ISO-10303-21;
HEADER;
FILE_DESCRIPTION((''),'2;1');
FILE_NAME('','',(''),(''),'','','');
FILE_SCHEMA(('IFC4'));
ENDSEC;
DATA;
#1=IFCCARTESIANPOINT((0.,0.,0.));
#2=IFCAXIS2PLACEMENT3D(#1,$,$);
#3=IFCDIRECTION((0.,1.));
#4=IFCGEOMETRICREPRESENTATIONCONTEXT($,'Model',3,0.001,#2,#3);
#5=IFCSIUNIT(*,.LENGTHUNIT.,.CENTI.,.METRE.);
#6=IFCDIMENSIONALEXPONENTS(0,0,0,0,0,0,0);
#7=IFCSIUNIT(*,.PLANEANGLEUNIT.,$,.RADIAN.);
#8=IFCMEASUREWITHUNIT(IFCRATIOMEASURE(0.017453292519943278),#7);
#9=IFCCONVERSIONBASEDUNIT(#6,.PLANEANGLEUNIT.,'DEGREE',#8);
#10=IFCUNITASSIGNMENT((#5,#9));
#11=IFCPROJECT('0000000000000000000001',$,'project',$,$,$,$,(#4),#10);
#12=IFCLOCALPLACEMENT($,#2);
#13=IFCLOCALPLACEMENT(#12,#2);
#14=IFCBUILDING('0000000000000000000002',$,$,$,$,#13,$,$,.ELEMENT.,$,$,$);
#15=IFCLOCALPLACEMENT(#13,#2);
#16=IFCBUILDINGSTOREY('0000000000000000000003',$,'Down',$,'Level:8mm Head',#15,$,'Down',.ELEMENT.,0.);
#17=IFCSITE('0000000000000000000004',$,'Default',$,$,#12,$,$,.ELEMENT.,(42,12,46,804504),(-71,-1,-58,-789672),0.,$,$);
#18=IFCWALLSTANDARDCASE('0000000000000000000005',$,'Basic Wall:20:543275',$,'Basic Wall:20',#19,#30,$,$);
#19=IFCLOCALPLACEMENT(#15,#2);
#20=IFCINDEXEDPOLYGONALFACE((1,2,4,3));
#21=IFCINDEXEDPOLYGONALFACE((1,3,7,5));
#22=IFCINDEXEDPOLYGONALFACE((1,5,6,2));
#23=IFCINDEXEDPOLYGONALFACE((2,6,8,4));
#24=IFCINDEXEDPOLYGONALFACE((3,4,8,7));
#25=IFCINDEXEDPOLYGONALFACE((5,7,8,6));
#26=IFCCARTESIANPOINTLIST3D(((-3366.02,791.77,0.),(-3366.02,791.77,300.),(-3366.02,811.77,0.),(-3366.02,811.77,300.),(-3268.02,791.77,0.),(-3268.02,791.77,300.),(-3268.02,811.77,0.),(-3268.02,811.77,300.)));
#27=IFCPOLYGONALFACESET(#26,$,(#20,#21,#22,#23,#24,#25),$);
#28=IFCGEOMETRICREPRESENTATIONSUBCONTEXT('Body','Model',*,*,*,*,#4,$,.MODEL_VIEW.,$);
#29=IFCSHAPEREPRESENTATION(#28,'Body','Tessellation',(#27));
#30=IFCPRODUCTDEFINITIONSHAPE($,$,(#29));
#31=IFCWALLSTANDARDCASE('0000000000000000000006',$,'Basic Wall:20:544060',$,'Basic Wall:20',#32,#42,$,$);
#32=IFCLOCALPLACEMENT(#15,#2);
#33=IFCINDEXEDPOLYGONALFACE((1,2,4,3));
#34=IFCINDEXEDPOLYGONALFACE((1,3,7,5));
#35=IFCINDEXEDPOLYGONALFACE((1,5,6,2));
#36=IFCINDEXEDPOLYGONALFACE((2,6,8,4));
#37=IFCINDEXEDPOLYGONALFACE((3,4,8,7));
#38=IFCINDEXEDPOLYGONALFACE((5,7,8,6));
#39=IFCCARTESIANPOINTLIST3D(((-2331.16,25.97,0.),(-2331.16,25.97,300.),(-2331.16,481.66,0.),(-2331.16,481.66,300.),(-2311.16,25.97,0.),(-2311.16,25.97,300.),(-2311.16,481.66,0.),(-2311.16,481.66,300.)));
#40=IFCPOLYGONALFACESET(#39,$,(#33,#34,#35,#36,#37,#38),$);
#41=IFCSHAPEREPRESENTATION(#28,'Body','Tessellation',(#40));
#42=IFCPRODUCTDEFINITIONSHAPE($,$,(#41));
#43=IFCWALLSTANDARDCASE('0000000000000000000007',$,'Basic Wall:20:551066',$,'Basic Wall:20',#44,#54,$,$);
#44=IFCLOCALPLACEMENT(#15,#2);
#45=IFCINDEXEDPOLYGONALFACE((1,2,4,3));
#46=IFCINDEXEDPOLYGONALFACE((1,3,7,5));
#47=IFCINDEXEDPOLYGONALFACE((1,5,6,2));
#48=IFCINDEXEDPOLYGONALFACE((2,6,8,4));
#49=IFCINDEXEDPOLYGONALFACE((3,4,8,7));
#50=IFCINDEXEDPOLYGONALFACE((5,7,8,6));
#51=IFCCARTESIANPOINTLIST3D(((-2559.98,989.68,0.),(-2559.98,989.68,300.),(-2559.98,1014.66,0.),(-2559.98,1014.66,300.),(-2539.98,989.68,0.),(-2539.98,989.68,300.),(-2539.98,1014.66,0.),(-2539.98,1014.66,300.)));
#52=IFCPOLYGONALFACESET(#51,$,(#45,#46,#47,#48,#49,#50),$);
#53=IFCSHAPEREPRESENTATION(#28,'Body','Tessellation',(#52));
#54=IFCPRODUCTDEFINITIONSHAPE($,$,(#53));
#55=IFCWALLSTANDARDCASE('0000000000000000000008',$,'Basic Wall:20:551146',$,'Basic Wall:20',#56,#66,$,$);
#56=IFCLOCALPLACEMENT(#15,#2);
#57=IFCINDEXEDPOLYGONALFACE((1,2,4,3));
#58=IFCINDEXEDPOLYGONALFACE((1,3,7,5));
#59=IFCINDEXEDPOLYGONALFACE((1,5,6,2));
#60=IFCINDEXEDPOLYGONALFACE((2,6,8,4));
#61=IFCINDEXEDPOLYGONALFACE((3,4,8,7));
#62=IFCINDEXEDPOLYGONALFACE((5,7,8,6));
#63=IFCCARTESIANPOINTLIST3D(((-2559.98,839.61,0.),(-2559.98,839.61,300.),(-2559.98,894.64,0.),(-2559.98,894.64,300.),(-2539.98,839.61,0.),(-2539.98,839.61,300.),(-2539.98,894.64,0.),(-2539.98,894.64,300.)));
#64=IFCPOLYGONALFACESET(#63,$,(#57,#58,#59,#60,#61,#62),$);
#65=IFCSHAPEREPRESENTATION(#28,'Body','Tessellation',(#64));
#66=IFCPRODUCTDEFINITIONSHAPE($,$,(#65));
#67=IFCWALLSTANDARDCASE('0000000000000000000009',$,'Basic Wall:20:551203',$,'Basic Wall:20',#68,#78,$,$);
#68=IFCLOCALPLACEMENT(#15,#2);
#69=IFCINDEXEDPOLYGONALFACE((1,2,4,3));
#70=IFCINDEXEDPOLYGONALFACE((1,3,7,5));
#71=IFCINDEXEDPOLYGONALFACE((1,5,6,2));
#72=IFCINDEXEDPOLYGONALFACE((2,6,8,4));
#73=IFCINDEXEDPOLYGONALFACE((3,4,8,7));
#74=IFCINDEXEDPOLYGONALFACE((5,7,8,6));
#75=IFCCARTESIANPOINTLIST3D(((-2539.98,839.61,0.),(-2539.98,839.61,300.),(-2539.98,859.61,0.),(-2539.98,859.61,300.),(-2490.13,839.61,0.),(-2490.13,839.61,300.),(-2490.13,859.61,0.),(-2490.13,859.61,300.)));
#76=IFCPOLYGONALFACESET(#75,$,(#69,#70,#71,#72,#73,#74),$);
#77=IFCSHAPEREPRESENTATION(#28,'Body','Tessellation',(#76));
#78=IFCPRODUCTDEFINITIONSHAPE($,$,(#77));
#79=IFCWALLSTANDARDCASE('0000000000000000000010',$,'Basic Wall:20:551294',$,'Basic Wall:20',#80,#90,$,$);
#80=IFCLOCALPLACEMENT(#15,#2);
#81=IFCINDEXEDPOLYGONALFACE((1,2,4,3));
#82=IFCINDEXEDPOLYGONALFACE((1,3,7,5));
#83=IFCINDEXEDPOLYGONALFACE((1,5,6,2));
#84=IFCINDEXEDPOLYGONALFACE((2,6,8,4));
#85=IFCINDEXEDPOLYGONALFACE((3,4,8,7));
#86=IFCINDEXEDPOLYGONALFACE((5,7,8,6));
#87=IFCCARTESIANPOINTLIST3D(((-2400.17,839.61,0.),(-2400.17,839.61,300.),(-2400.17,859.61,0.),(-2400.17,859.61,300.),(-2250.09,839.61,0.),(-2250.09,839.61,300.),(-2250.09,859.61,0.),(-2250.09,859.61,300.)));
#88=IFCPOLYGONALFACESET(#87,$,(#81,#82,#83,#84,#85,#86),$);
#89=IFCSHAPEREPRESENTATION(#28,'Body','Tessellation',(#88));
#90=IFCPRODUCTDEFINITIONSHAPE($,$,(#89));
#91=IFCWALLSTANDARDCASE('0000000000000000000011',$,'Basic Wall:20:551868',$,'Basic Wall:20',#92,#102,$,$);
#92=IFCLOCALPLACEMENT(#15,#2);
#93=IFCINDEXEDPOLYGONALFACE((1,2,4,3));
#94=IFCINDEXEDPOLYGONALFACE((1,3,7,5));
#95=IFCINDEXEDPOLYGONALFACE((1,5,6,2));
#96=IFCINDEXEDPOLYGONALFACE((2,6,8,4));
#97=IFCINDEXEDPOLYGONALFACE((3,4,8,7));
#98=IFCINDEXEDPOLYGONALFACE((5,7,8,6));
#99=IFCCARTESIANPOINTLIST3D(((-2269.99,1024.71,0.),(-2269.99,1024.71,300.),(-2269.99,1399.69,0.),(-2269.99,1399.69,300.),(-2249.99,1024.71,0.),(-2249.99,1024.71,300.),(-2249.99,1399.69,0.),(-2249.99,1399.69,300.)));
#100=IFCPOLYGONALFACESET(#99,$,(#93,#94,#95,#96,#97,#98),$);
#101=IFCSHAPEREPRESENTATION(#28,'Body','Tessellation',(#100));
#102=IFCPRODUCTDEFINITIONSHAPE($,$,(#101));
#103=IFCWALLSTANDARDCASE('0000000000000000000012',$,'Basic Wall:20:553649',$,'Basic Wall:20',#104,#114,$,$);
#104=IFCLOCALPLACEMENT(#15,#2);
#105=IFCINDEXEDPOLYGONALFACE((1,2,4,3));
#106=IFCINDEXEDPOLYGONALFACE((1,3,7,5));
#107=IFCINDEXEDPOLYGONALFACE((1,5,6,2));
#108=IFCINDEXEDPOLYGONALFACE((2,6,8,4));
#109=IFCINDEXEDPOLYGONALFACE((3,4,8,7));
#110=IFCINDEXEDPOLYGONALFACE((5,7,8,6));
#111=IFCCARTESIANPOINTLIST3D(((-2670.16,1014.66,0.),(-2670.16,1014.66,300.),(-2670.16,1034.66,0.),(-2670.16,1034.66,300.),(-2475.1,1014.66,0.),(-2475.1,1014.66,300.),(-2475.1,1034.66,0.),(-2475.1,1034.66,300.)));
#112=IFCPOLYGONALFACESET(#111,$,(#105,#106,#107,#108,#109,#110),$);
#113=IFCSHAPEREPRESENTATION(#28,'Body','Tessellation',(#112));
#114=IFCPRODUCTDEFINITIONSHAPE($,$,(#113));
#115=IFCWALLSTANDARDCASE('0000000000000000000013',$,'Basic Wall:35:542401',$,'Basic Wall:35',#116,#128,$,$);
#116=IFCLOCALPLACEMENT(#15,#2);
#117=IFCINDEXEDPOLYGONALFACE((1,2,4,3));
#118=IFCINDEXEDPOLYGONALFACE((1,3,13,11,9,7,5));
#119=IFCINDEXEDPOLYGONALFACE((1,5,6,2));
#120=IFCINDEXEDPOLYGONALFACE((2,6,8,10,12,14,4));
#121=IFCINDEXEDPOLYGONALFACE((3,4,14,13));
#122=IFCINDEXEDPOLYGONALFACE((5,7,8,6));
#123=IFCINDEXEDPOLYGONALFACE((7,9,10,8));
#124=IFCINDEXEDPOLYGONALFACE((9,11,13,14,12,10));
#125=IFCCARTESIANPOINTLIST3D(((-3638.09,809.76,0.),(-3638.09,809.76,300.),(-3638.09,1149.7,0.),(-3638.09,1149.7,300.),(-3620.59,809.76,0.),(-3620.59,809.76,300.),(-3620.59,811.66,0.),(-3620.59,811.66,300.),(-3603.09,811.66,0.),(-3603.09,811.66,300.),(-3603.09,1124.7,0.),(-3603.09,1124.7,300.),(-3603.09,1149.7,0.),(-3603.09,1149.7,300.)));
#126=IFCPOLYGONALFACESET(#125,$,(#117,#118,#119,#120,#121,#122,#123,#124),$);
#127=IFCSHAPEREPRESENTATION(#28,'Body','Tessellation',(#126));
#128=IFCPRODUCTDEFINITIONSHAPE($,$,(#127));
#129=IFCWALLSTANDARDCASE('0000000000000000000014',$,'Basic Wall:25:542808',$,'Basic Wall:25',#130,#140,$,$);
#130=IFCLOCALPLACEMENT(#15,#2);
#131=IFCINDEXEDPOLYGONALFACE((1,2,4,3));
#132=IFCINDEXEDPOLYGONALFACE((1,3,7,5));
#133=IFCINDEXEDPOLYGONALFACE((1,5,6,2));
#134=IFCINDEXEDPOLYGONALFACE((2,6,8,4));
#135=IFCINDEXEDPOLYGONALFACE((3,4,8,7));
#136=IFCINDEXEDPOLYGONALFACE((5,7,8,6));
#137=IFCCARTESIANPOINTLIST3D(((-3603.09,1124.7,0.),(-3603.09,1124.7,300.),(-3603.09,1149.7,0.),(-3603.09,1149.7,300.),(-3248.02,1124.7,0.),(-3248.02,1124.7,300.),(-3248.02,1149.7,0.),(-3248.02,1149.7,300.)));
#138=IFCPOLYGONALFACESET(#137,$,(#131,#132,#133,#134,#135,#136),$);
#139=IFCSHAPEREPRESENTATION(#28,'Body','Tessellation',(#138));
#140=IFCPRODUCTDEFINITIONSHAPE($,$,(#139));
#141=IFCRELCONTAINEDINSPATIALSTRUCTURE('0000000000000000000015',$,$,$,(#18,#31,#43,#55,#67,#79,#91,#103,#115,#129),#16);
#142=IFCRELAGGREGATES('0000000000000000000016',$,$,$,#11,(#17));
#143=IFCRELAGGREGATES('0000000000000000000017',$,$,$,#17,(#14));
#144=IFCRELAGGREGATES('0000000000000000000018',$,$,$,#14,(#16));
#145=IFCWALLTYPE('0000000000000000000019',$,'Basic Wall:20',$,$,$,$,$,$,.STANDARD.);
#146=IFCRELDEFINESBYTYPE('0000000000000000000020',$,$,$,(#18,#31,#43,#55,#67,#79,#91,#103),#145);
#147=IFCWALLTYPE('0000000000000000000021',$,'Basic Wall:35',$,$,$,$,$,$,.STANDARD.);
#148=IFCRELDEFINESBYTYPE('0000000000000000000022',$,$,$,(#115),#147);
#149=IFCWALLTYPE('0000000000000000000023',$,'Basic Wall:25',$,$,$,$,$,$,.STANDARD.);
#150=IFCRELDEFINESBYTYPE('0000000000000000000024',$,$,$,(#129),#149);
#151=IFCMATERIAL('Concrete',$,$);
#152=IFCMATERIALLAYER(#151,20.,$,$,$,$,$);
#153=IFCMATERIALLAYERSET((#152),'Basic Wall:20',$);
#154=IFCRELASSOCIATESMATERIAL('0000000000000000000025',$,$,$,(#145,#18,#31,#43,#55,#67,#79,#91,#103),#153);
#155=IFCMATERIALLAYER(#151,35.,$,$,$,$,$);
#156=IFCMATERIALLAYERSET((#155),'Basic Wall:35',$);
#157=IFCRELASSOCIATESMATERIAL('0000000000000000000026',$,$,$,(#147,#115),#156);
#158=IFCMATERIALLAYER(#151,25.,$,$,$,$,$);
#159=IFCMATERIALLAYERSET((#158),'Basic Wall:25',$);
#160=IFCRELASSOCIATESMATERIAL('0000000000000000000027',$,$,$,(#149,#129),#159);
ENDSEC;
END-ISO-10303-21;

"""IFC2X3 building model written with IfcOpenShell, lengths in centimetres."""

from ifc_helpers import new_model, entity, si_unit, converted_unit, direction, frame, frame_2d, origin, place, context, subcontext, project, spatial, polyline, rectangle, outline, extrude, material, layer, layer_set, layer_usage, type_object, element, save


model = new_model("IFC2X3")

# Units and contexts
model_context = context("Model", 3, precision=0.001, world=origin(), true_north=direction((0.0, 1.0)))
body_context = subcontext(model_context, "Body", "Model", "MODEL_VIEW")
ifc_project = project(units=[si_unit("LENGTHUNIT", "METRE", prefix="CENTI"), converted_unit("PLANEANGLEUNIT", "DEGREE", entity("IfcRatioMeasure", 0.017453292519943278), si_unit("PLANEANGLEUNIT", "RADIAN"), dimensions=[0, 0, 0, 0, 0, 0, 0])], contexts=[model_context])

# Site, building, storey
site_placement = place(None, origin())
site = spatial("IfcSite", under=ifc_project, at=site_placement, Name="Default", CompositionType="ELEMENT", RefLatitude=(42, 12, 46, 804504), RefLongitude=(-71, -1, -58, -789672), RefElevation=0.0)
building_placement = place(site_placement, origin())
building = spatial("IfcBuilding", under=site, at=building_placement, CompositionType="ELEMENT")
storey_placement = place(building_placement, origin())
storey = spatial("IfcBuildingStorey", under=building, at=storey_placement, Name="Down", ObjectType="Level:8mm Head", LongName="Down", CompositionType="ELEMENT", Elevation=0.0)

# Walls
ifc_material = material(Name="Concrete")
ifc_layer_1 = layer(ifc_material, 20.0)
ifc_layer_set_1 = layer_set([ifc_layer_1], Name="Basic Wall:20")
wall_type_1 = type_object("IfcWallType", Name="Basic Wall:20", PredefinedType="STANDARD", material=ifc_layer_set_1)
ifc_layer_usage_1 = layer_usage(ifc_layer_set_1, "AXIS2", "NEGATIVE", 10.0)
wall_1_placement = place(storey_placement, frame((-3268.02, 801.77, 0.0), z_axis=(0.0, 0.0, 1.0), x_axis=(-1.0, 0.0, 0.0)))
element("IfcWallStandardCase", 1, at=wall_1_placement, inside=storey, type_object=wall_type_1, material=ifc_layer_usage_1, Name="Basic Wall:20:543275", ObjectType="Basic Wall:20", context=body_context, shape_type="SweptSolid", body=[
    extrude(rectangle(XDim=98.0, YDim=20.0, at=frame_2d((49.0, 0.0), x_axis=(-1.0, 0.0))), origin(), (0.0, 0.0, 1.0), 300.0),
])
ifc_layer_usage_2 = layer_usage(ifc_layer_set_1, "AXIS2", "POSITIVE", -10.0)
wall_2_placement = place(storey_placement, frame((-2321.16, 481.66, 0.0), z_axis=(0.0, 0.0, 1.0), x_axis=(0.0, -1.0, 0.0)))
element("IfcWallStandardCase", 2, at=wall_2_placement, inside=storey, type_object=wall_type_1, material=ifc_layer_usage_2, Name="Basic Wall:20:544060", ObjectType="Basic Wall:20", context=body_context, shape_type="SweptSolid", body=[
    extrude(rectangle(XDim=455.69, YDim=20.0, at=frame_2d((227.85, 0.0), x_axis=(-1.0, 0.0))), origin(), (0.0, 0.0, 1.0), 300.0),
])
ifc_layer_usage_3 = layer_usage(ifc_layer_set_1, "AXIS2", "NEGATIVE", 10.0)
wall_3_placement = place(storey_placement, frame((-2549.98, 989.68, 0.0), z_axis=(0.0, 0.0, 1.0), x_axis=(0.0, 1.0, 0.0)))
element("IfcWallStandardCase", 3, at=wall_3_placement, inside=storey, type_object=wall_type_1, material=ifc_layer_usage_3, Name="Basic Wall:20:551066", ObjectType="Basic Wall:20", context=body_context, shape_type="SweptSolid", body=[
    extrude(rectangle(XDim=24.98, YDim=20.0, at=frame_2d((12.49, 0.0), x_axis=(-1.0, 0.0))), origin(), (0.0, 0.0, 1.0), 300.0),
])
ifc_layer_usage_4 = layer_usage(ifc_layer_set_1, "AXIS2", "POSITIVE", -10.0)
wall_4_placement = place(storey_placement, frame((-2549.98, 894.64, 0.0), z_axis=(0.0, 0.0, 1.0), x_axis=(0.0, -1.0, 0.0)))
element("IfcWallStandardCase", 4, at=wall_4_placement, inside=storey, type_object=wall_type_1, material=ifc_layer_usage_4, Name="Basic Wall:20:551146", ObjectType="Basic Wall:20", context=body_context, shape_type="SweptSolid", body=[
    extrude(rectangle(XDim=55.03, YDim=20.0, at=frame_2d((27.52, 0.0), x_axis=(-1.0, 0.0))), origin(), (0.0, 0.0, 1.0), 300.0),
])
ifc_layer_usage_5 = layer_usage(ifc_layer_set_1, "AXIS2", "POSITIVE", -10.0)
wall_5_placement = place(storey_placement, frame((-2539.98, 849.61, 0.0)))
element("IfcWallStandardCase", 5, at=wall_5_placement, inside=storey, type_object=wall_type_1, material=ifc_layer_usage_5, Name="Basic Wall:20:551203", ObjectType="Basic Wall:20", context=body_context, shape_type="SweptSolid", body=[
    extrude(rectangle(XDim=49.85, YDim=20.0, at=frame_2d((24.93, 0.0), x_axis=(-1.0, 0.0))), origin(), (0.0, 0.0, 1.0), 300.0),
])
ifc_layer_usage_6 = layer_usage(ifc_layer_set_1, "AXIS2", "POSITIVE", -10.0)
wall_6_placement = place(storey_placement, frame((-2400.17, 849.61, 0.0)))
element("IfcWallStandardCase", 6, at=wall_6_placement, inside=storey, type_object=wall_type_1, material=ifc_layer_usage_6, Name="Basic Wall:20:551294", ObjectType="Basic Wall:20", context=body_context, shape_type="SweptSolid", body=[
    extrude(rectangle(XDim=150.07, YDim=20.0, at=frame_2d((75.04, 0.0), x_axis=(-1.0, 0.0))), origin(), (0.0, 0.0, 1.0), 300.0),
])
ifc_layer_usage_7 = layer_usage(ifc_layer_set_1, "AXIS2", "NEGATIVE", 10.0)
wall_7_placement = place(storey_placement, frame((-2259.99, 1024.71, 0.0), z_axis=(0.0, 0.0, 1.0), x_axis=(0.0, 1.0, 0.0)))
element("IfcWallStandardCase", 7, at=wall_7_placement, inside=storey, type_object=wall_type_1, material=ifc_layer_usage_7, Name="Basic Wall:20:551868", ObjectType="Basic Wall:20", context=body_context, shape_type="SweptSolid", body=[
    extrude(rectangle(XDim=374.98, YDim=20.0, at=frame_2d((187.49, 0.0), x_axis=(-1.0, 0.0))), origin(), (0.0, 0.0, 1.0), 300.0),
])
ifc_layer_usage_8 = layer_usage(ifc_layer_set_1, "AXIS2", "POSITIVE", -10.0)
wall_8_placement = place(storey_placement, frame((-2670.16, 1024.66, 0.0)))
element("IfcWallStandardCase", 8, at=wall_8_placement, inside=storey, type_object=wall_type_1, material=ifc_layer_usage_8, Name="Basic Wall:20:553649", ObjectType="Basic Wall:20", context=body_context, shape_type="SweptSolid", body=[
    extrude(rectangle(XDim=195.06, YDim=20.0, at=frame_2d((97.53, 0.0), x_axis=(-1.0, 0.0))), origin(), (0.0, 0.0, 1.0), 300.0),
])
ifc_layer_2 = layer(ifc_material, 35.0)
ifc_layer_set_2 = layer_set([ifc_layer_2], Name="Basic Wall:35")
ifc_layer_usage_9 = layer_usage(ifc_layer_set_2, "AXIS2", "POSITIVE", -17.5)
wall_type_2 = type_object("IfcWallType", Name="Basic Wall:35", PredefinedType="STANDARD", material=ifc_layer_set_2)
wall_9_placement = place(storey_placement, frame((-3620.59, 809.76, 0.0), z_axis=(0.0, 0.0, 1.0), x_axis=(0.0, 1.0, 0.0)))
element("IfcWallStandardCase", 9, at=wall_9_placement, inside=storey, type_object=wall_type_2, material=ifc_layer_usage_9, Name="Basic Wall:35:542401", ObjectType="Basic Wall:35", context=body_context, shape_type="SweptSolid", body=[
    extrude(outline(polyline([(339.94, -17.5), (339.94, 17.5), (0.0, 17.5), (0.0, 0.0), (1.91, 0.0), (1.91, -17.5), (314.94, -17.5), (339.94, -17.5)])), origin(), (0.0, 0.0, 1.0), 300.0),
])
ifc_layer_3 = layer(ifc_material, 25.0)
ifc_layer_set_3 = layer_set([ifc_layer_3], Name="Basic Wall:25")
ifc_layer_usage_10 = layer_usage(ifc_layer_set_3, "AXIS2", "NEGATIVE", 12.5)
wall_type_3 = type_object("IfcWallType", Name="Basic Wall:25", PredefinedType="STANDARD", material=ifc_layer_set_3)
wall_10_placement = place(storey_placement, frame((-3603.09, 1137.2, 0.0)))
element("IfcWallStandardCase", 10, at=wall_10_placement, inside=storey, type_object=wall_type_3, material=ifc_layer_usage_10, Name="Basic Wall:25:542808", ObjectType="Basic Wall:25", context=body_context, shape_type="SweptSolid", body=[
    extrude(rectangle(XDim=355.08, YDim=25.0, at=frame_2d((177.54, 0.0), x_axis=(-1.0, 0.0))), origin(), (0.0, 0.0, 1.0), 300.0),
])

save(model, "model.ifc")
